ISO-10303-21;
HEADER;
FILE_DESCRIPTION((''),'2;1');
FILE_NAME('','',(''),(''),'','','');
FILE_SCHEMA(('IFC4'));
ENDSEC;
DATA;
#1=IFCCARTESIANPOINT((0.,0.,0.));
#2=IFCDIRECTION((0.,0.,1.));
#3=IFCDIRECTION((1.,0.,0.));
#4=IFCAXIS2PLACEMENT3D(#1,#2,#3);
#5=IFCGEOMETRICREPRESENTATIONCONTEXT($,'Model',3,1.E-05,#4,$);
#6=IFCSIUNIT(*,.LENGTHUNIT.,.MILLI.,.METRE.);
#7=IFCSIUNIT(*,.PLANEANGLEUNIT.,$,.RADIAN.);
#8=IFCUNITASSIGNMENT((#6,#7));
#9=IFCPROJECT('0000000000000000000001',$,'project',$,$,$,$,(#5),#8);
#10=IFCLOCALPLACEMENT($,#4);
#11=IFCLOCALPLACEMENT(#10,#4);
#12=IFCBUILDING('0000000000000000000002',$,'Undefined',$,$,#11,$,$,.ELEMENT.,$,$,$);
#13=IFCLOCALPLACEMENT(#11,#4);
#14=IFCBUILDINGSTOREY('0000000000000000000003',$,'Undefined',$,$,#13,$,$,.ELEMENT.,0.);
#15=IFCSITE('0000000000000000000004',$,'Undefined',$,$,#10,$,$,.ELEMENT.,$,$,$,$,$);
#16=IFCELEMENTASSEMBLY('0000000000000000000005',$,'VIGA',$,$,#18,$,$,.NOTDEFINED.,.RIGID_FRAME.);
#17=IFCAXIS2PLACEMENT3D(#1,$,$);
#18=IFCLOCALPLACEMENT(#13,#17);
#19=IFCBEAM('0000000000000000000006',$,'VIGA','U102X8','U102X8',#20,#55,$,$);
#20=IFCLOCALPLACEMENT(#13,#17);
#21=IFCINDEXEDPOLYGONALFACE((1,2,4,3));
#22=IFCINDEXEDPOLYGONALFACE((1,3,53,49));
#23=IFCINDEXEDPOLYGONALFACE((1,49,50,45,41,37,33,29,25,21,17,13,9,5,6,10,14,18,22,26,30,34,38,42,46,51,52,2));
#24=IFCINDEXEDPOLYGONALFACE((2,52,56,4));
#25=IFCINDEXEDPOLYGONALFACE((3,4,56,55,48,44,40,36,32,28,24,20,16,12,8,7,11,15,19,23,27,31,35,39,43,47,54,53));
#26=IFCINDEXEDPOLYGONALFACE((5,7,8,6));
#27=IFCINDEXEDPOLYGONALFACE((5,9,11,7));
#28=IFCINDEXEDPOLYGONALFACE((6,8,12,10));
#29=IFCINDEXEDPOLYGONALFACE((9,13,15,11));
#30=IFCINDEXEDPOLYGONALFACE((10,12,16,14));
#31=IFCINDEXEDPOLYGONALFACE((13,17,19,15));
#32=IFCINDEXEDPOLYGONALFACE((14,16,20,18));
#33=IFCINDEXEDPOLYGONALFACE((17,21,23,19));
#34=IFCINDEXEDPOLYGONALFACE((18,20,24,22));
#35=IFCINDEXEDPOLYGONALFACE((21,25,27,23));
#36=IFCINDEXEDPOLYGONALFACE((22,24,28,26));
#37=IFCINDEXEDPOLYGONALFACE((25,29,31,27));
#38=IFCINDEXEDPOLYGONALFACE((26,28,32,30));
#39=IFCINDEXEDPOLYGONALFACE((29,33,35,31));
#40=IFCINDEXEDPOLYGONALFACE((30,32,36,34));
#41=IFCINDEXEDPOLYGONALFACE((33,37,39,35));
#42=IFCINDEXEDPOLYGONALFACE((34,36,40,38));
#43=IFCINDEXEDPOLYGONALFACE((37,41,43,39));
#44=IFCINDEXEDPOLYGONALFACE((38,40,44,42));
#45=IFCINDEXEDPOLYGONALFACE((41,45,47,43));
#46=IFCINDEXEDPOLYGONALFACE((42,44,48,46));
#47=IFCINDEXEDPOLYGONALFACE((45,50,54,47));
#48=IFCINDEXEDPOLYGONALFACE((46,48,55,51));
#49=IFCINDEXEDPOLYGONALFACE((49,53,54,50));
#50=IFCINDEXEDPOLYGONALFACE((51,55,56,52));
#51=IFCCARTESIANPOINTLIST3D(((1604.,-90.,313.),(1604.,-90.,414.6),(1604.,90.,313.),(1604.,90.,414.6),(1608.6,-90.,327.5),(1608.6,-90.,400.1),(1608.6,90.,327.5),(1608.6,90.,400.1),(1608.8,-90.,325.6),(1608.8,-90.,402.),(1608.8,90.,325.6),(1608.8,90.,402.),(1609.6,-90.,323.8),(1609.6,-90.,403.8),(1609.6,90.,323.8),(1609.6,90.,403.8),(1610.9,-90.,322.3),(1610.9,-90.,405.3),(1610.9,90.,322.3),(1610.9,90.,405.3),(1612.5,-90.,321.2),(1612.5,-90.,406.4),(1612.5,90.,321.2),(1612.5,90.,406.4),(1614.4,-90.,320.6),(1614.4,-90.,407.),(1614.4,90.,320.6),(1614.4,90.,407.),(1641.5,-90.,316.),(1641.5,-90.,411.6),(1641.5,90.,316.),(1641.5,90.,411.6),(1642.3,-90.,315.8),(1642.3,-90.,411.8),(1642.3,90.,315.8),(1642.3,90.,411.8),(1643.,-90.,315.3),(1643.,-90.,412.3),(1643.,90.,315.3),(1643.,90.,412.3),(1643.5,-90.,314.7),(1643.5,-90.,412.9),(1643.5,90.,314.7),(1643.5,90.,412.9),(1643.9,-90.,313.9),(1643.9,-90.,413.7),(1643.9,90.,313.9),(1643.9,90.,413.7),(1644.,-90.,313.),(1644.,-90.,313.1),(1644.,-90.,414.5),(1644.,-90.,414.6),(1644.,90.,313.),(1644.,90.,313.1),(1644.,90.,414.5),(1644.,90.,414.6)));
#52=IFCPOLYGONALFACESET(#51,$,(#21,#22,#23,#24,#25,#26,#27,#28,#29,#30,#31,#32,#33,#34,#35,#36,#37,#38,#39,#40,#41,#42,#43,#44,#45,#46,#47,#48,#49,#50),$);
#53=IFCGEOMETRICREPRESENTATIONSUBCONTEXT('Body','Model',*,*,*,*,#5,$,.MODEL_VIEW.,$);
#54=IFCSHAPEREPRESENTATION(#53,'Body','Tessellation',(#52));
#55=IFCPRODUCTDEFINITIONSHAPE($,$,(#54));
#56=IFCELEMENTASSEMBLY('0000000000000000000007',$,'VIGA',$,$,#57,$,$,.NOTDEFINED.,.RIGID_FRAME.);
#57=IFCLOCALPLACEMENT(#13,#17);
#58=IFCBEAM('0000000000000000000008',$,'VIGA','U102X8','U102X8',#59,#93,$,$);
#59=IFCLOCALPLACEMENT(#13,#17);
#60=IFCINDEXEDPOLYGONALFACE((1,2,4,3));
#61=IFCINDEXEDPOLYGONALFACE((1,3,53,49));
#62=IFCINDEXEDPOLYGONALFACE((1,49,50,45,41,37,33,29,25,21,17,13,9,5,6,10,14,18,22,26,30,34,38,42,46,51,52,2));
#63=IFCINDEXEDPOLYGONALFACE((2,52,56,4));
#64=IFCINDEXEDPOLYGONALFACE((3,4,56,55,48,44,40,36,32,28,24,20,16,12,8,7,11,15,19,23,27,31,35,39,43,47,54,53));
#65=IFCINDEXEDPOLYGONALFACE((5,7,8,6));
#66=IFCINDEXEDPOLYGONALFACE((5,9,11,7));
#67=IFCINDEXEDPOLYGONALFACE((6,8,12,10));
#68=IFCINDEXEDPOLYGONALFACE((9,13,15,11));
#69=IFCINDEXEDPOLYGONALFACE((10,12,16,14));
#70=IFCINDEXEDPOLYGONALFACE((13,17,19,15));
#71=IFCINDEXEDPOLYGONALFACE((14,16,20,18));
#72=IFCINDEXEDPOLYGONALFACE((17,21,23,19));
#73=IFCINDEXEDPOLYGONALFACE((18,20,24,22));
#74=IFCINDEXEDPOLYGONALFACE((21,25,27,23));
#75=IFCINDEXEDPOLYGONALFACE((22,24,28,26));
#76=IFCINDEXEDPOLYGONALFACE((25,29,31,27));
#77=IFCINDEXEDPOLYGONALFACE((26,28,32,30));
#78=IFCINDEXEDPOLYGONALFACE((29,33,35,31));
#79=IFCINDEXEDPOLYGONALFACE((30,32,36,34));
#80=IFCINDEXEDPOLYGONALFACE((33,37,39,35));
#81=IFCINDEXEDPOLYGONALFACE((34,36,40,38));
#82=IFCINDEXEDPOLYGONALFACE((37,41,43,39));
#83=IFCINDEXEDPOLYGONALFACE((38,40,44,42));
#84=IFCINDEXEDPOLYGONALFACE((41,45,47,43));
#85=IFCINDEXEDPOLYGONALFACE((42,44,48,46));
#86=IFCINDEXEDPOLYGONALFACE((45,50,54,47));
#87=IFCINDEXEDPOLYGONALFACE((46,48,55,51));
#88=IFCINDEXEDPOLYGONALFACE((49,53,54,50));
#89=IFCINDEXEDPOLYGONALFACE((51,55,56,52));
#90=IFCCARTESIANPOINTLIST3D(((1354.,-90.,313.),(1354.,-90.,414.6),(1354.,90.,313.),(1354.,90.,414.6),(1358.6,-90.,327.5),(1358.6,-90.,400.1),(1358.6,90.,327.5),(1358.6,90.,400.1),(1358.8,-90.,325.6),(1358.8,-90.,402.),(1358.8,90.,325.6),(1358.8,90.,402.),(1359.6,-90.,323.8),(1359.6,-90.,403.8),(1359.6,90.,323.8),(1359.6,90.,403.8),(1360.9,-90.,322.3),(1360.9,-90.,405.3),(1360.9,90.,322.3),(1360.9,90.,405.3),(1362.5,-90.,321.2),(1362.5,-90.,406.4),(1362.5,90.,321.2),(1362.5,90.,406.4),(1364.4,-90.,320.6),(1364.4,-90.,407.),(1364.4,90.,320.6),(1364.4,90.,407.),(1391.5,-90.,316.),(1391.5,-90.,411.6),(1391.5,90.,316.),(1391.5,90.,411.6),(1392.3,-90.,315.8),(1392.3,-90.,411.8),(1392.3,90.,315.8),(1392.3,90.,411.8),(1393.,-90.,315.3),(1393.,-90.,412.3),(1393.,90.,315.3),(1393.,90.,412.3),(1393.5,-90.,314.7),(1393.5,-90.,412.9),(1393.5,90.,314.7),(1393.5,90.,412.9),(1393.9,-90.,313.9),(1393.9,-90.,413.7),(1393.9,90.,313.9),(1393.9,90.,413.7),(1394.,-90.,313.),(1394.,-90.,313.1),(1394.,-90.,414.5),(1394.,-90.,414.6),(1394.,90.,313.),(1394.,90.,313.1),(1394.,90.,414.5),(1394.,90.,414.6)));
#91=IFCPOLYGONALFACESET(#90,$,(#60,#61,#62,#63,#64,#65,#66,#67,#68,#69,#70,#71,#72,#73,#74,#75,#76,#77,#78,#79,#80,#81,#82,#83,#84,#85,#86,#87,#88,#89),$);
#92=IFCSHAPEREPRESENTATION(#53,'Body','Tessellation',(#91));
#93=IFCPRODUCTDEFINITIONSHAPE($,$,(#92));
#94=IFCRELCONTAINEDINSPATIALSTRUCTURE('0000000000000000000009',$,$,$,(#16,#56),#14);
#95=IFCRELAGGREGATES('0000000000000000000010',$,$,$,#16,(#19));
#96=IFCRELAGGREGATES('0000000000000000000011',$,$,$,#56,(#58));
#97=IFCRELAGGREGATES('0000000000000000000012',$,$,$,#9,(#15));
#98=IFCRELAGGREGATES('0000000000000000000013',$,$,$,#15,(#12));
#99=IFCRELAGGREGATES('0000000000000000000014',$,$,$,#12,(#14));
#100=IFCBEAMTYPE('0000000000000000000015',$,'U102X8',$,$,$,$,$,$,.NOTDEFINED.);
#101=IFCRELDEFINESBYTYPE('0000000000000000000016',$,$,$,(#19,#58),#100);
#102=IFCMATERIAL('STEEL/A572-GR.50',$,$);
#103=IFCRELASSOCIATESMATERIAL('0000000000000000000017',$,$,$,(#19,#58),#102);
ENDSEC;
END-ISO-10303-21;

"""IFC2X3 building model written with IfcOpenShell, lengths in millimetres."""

from ifc_helpers import new_model, si_unit, frame, origin_with_axes, origin_2d_with_axis, place, context, subcontext, project, spatial, u_section, extrude, material, type_object, element, aggregate, save


model = new_model("IFC2X3")

# Units and contexts
model_context = context("Model", 3, precision=1e-05, world=origin_with_axes())
body_context = subcontext(model_context, "Body", "Model", "MODEL_VIEW")
ifc_project = project(units=[si_unit("LENGTHUNIT", "METRE", prefix="MILLI"), si_unit("PLANEANGLEUNIT", "RADIAN")], contexts=[model_context])

# Site, building, storey
site_placement = place(None, origin_with_axes())
site = spatial("IfcSite", under=ifc_project, at=site_placement, Name="Undefined", CompositionType="ELEMENT")
building_placement = place(site_placement, origin_with_axes())
building = spatial("IfcBuilding", under=site, at=building_placement, Name="Undefined", CompositionType="ELEMENT")
storey_placement = place(building_placement, origin_with_axes())
storey = spatial("IfcBuildingStorey", under=building, at=storey_placement, Name="Undefined", CompositionType="ELEMENT", Elevation=0.0)

# Element assemblies, beams
ifc_material = material(Name="STEEL/A572-GR.50")
beam_type = type_object("IfcBeamType", Name="U102X8", PredefinedType="NOTDEFINED")
assembly_1_placement = place(storey_placement, origin_with_axes())
assembly_1 = element("IfcElementAssembly", 1, at=assembly_1_placement, inside=storey, Name="VIGA", AssemblyPlace="NOTDEFINED", PredefinedType="RIGID_FRAME")
beam_1_placement = place(assembly_1_placement, frame((1624.0, -90.0, 363.8), z_axis=(0.0, 0.0, 1.0), x_axis=(0.0, 1.0, 0.0)))
beam_1 = element("IfcBeam", 2, at=beam_1_placement, type_object=beam_type, material=ifc_material, Name="VIGA", Description="U102X8", ObjectType="U102X8", context=body_context, shape_type="SweptSolid", body=[
    extrude(u_section(Depth=101.6, FlangeWidth=40.0, WebThickness=4.6, FlangeThickness=6.0, FilletRadius=7.0, EdgeRadius=3.0, FlangeSlope=0.16839, at=origin_2d_with_axis()), frame((180.0, 0.0, 0.0), z_axis=(-1.0, 0.0, 0.0), x_axis=(0.0, -1.0, 0.0)), (0.0, 0.0, 1.0), 180.0),
])
aggregate(assembly_1, [beam_1])
assembly_2_placement = place(storey_placement, origin_with_axes())
assembly_2 = element("IfcElementAssembly", 3, at=assembly_2_placement, inside=storey, Name="VIGA", AssemblyPlace="NOTDEFINED", PredefinedType="RIGID_FRAME")
beam_2_placement = place(assembly_2_placement, frame((1374.0, -90.0, 363.8), z_axis=(0.0, 0.0, 1.0), x_axis=(0.0, 1.0, 0.0)))
beam_2 = element("IfcBeam", 4, at=beam_2_placement, type_object=beam_type, material=ifc_material, Name="VIGA", Description="U102X8", ObjectType="U102X8", context=body_context, shape_type="SweptSolid", body=[
    extrude(u_section(Depth=101.6, FlangeWidth=40.0, WebThickness=4.6, FlangeThickness=6.0, FilletRadius=7.0, EdgeRadius=3.0, FlangeSlope=0.16839, at=origin_2d_with_axis()), frame((180.0, 0.0, 0.0), z_axis=(-1.0, 0.0, 0.0), x_axis=(0.0, -1.0, 0.0)), (0.0, 0.0, 1.0), 180.0),
])
aggregate(assembly_2, [beam_2])

save(model, "model.ifc")
